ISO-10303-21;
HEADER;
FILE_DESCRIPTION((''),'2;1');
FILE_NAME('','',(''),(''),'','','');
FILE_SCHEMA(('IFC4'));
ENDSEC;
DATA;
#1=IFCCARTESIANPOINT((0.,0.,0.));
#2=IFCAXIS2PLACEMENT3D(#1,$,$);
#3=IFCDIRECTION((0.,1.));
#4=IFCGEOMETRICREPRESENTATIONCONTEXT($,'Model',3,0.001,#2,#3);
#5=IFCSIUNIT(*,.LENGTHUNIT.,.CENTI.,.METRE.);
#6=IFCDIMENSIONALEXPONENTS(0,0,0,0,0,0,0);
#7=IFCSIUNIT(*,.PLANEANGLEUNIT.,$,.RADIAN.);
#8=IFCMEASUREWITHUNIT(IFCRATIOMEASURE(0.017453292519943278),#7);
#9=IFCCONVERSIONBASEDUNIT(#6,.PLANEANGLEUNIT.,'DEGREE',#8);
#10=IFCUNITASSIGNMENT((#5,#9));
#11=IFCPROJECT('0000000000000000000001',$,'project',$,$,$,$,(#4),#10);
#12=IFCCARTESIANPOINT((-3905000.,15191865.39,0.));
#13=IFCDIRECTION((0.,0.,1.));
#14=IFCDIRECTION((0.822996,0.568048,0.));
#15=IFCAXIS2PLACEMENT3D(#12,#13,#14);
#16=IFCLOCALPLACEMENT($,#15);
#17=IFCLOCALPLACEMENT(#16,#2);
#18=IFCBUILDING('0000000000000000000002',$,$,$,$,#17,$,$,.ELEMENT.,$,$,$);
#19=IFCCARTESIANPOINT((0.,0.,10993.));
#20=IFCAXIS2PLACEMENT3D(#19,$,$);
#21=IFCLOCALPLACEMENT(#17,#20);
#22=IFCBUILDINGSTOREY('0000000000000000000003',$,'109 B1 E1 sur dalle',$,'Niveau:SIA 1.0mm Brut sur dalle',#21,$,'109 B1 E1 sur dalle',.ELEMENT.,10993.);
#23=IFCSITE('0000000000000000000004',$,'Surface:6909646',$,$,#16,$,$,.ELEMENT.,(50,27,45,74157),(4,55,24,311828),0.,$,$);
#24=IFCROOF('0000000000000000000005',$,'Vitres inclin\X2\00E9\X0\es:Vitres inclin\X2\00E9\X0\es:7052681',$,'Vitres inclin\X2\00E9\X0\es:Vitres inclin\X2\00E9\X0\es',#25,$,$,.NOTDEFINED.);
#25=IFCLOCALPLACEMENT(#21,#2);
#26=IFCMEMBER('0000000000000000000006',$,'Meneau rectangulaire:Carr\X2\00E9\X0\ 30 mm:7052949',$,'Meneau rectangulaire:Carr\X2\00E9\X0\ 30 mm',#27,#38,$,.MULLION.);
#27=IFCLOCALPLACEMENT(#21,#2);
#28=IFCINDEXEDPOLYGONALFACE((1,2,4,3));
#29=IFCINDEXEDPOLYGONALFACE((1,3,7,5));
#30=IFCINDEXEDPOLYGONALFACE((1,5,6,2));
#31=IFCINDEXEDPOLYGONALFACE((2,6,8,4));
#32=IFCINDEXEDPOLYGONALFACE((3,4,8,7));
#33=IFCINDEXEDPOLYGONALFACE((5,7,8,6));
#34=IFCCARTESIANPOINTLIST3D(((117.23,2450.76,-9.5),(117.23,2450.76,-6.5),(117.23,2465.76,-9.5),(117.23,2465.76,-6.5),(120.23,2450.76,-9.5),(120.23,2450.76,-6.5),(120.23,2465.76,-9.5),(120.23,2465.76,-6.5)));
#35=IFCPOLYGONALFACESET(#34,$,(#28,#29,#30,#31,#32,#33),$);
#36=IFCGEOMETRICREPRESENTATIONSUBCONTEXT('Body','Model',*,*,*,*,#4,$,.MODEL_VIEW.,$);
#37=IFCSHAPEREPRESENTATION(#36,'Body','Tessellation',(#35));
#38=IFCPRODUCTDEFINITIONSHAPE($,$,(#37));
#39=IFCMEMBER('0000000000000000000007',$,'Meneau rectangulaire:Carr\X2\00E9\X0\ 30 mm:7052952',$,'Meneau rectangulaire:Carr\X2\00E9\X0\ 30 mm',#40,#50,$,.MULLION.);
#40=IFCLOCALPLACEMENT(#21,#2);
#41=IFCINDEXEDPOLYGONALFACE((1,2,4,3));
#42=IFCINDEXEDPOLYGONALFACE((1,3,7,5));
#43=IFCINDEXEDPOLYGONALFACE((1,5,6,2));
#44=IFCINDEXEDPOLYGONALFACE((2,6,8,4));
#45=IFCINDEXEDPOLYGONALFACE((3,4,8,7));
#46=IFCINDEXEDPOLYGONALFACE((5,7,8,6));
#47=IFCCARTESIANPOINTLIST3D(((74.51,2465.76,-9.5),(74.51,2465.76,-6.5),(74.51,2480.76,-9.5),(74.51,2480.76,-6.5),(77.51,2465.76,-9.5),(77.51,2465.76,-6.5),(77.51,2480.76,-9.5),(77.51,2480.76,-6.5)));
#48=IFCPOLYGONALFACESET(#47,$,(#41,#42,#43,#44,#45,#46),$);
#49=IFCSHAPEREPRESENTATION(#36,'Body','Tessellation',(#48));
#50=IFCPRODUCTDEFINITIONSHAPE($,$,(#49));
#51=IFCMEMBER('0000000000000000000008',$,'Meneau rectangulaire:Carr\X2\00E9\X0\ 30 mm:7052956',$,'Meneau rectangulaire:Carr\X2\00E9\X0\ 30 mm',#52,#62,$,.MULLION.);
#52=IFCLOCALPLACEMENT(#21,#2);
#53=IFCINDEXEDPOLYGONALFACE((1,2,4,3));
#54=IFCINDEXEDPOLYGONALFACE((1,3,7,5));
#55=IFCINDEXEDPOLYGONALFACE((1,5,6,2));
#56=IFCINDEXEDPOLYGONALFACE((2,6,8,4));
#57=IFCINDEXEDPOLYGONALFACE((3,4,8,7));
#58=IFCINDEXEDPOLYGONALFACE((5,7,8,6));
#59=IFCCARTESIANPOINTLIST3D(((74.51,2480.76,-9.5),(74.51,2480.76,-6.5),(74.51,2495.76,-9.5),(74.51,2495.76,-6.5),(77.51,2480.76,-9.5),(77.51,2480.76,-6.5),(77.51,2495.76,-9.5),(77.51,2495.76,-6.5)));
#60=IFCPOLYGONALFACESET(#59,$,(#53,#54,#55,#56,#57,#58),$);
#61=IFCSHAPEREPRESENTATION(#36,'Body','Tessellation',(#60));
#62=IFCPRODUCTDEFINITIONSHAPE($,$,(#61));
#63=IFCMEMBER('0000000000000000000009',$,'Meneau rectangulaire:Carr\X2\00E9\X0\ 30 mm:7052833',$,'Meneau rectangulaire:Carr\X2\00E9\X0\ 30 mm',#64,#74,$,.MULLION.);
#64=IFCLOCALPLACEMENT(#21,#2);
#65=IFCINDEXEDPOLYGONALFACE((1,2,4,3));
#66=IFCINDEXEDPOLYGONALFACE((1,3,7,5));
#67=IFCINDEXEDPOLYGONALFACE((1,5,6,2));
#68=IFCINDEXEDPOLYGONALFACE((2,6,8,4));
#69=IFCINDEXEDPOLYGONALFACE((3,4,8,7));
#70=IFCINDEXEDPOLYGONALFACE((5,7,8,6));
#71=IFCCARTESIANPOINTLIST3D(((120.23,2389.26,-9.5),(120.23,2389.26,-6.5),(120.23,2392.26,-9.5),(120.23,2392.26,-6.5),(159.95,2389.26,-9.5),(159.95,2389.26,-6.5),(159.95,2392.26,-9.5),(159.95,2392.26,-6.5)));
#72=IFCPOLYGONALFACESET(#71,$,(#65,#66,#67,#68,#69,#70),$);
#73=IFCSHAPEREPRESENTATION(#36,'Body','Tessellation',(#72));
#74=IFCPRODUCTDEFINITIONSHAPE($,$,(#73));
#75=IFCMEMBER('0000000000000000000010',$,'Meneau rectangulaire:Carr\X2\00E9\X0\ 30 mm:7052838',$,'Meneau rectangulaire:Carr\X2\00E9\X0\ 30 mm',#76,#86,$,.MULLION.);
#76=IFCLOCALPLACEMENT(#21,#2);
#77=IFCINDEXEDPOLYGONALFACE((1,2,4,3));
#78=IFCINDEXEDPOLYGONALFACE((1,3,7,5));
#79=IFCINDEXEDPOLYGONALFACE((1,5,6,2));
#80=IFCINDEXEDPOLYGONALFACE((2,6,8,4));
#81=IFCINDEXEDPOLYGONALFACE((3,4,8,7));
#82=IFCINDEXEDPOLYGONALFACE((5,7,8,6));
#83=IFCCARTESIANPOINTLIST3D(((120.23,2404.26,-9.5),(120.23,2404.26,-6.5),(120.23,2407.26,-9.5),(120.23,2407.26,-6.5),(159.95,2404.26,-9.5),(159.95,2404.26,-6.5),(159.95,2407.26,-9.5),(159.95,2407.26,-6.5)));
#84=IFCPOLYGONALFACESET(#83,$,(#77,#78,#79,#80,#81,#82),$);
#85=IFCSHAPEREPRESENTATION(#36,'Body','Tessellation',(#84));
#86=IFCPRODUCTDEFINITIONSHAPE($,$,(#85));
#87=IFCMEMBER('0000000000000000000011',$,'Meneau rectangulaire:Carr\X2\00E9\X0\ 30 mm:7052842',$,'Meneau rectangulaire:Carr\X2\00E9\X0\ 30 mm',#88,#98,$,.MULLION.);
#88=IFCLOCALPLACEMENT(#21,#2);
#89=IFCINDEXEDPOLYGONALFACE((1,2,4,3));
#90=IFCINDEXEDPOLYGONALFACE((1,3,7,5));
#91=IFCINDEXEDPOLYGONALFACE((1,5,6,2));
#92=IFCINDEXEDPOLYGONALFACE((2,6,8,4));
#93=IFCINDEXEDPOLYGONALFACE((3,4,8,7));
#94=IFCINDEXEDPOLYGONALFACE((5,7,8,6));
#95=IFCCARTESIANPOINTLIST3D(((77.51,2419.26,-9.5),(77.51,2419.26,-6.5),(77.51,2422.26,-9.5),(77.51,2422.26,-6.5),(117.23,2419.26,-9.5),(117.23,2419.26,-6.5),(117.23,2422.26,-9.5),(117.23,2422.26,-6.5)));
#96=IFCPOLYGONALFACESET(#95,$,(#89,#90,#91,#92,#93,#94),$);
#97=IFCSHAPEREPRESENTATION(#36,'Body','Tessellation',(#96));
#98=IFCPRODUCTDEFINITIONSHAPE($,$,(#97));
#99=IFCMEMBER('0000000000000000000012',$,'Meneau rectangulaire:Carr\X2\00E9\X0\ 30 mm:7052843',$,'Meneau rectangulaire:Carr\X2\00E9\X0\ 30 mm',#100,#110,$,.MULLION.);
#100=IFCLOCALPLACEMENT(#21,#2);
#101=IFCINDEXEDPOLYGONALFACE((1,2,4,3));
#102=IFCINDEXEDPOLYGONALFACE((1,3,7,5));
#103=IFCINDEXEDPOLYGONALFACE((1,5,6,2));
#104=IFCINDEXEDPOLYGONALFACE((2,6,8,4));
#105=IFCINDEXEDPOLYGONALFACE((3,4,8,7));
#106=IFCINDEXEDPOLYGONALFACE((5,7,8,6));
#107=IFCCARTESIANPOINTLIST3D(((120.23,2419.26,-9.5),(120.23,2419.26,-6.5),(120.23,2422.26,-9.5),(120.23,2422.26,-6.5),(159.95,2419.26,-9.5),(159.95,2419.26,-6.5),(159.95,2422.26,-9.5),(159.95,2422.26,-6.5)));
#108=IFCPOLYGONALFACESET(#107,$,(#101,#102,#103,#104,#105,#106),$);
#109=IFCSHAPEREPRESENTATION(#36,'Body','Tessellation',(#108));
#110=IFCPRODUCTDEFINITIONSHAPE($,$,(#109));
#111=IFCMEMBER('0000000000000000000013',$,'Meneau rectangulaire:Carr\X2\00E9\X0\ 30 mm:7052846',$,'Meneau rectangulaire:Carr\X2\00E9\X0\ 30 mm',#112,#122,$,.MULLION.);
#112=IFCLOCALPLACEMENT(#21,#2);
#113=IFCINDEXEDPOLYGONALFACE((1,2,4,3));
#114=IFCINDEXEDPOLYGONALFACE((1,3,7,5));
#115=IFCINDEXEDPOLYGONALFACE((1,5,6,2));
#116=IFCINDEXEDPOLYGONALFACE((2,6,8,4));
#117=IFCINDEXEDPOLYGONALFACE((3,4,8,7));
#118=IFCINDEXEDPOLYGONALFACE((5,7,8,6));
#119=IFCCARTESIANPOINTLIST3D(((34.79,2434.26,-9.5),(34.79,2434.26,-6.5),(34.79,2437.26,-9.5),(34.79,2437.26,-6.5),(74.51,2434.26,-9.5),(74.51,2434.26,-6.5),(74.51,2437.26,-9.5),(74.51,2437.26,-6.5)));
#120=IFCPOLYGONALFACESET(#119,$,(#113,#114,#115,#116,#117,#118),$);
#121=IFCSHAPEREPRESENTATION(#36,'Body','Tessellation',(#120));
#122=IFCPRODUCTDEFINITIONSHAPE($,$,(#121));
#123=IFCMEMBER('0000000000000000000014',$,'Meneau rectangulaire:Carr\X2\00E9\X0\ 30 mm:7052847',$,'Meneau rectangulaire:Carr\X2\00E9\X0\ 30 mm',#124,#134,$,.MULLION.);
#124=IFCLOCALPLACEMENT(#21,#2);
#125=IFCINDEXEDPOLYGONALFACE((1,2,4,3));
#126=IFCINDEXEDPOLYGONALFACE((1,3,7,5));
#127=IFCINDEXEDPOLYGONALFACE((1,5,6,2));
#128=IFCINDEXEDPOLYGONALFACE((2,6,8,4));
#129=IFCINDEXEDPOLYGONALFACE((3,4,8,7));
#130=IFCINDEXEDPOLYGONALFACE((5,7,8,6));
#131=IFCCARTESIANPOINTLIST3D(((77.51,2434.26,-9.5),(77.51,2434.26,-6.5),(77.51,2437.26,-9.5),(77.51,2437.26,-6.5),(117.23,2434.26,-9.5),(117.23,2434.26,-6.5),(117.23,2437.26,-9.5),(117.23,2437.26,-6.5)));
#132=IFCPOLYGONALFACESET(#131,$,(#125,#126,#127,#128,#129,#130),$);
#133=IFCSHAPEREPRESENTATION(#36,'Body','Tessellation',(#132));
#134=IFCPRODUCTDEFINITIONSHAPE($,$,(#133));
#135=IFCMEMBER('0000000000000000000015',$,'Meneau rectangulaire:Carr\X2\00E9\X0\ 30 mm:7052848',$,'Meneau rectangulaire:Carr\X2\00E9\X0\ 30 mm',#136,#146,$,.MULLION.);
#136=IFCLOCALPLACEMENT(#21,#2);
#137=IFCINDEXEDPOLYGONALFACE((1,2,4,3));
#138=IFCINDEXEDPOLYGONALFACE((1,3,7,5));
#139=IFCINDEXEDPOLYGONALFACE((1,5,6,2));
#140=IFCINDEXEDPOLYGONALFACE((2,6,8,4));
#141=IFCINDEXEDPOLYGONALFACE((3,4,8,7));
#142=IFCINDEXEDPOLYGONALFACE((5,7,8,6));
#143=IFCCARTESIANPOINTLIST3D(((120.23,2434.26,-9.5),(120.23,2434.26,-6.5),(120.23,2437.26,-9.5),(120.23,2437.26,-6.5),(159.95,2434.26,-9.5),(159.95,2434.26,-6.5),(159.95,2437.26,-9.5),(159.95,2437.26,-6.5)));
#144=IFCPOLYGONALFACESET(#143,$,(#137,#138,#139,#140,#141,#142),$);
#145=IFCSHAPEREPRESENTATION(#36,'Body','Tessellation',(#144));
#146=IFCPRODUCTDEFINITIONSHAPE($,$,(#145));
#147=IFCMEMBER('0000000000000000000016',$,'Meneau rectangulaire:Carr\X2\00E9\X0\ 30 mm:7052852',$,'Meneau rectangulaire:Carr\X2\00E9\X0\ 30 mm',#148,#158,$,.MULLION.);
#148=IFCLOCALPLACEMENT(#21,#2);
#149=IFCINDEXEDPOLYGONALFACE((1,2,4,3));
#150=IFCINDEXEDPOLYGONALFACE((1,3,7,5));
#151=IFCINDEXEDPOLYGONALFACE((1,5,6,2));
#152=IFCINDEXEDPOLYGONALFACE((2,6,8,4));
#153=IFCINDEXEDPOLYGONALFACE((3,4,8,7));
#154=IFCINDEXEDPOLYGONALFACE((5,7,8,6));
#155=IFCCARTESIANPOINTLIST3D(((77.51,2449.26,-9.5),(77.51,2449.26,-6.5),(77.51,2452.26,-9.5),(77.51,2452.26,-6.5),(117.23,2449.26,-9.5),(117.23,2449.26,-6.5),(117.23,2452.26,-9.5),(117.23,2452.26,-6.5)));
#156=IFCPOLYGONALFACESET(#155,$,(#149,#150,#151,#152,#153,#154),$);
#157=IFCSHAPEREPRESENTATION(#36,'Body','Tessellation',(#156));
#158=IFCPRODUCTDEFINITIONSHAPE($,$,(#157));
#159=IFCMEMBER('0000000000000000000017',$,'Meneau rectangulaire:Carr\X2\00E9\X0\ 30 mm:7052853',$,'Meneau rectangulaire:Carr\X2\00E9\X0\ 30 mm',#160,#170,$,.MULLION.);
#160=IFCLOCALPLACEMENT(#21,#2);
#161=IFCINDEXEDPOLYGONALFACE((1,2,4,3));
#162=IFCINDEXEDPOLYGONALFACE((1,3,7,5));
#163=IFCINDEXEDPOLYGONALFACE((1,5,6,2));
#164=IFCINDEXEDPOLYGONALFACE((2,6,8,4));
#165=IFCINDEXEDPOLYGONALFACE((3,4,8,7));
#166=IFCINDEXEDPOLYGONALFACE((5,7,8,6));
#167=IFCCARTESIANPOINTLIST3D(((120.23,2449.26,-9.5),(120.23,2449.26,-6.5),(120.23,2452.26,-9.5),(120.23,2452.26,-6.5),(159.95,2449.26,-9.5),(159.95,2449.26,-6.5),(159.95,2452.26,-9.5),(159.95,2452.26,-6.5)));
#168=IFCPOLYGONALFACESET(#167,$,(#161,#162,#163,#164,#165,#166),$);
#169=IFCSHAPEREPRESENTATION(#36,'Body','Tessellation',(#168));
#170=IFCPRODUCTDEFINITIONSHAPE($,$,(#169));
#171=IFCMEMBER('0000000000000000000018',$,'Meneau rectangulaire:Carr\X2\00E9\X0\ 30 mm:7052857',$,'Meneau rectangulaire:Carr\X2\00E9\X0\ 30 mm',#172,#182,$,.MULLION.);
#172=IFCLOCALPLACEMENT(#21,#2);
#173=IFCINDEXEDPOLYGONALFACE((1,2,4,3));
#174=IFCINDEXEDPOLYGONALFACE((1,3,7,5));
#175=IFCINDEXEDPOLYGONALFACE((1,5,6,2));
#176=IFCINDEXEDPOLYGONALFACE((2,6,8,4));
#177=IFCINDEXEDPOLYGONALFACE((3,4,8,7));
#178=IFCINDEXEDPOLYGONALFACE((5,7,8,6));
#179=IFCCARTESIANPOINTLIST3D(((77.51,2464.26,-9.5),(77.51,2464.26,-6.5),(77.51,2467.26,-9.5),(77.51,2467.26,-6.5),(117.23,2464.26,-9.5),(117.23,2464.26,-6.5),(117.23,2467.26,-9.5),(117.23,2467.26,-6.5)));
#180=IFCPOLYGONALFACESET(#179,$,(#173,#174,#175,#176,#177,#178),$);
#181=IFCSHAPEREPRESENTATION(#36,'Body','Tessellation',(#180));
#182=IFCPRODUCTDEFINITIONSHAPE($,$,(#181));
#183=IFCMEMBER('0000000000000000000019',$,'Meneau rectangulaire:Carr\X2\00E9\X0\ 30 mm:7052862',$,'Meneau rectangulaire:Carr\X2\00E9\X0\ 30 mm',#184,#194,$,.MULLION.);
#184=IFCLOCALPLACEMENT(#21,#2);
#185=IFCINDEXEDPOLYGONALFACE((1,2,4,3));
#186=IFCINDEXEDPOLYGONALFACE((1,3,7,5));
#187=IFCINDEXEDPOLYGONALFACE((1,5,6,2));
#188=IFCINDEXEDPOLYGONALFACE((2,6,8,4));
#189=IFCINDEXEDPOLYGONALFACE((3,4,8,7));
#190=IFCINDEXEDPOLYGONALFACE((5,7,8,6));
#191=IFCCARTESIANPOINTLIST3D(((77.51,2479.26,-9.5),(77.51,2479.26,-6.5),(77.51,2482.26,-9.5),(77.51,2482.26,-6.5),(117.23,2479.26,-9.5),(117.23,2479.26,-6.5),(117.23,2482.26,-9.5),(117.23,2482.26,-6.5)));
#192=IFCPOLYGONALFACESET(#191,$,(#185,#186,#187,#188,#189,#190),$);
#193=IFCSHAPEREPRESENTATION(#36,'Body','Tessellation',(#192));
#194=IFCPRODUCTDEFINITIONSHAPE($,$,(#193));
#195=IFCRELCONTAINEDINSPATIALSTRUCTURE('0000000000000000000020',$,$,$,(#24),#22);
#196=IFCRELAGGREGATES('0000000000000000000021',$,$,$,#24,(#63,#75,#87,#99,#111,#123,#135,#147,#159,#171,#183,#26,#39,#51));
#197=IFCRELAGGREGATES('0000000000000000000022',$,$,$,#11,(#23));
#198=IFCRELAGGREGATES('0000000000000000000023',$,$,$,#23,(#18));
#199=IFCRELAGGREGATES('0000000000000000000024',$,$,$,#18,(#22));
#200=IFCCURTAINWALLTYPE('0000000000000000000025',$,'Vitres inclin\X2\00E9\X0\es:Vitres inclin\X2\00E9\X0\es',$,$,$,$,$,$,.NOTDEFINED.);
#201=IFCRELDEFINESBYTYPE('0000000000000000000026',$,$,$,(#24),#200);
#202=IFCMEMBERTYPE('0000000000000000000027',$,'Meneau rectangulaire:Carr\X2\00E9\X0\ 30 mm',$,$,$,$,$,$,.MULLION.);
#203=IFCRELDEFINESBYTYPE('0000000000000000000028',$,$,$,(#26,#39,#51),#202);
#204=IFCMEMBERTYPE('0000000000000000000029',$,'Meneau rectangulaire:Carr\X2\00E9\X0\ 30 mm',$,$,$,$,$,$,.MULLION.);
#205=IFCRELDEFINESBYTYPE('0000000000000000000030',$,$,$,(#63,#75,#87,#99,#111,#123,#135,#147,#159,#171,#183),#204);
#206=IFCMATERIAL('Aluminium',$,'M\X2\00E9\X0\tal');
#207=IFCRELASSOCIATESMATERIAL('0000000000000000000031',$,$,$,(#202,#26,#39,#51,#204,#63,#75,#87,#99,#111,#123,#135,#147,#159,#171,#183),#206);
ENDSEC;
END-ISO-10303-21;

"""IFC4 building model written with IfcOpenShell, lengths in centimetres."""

from ifc_helpers import new_model, entity, si_unit, converted_unit, direction, frame, origin, place, context, subcontext, project, spatial, indexed_curve, outline, extrude, source, transform, mapped, material, type_object, type_shapes, element, aggregate, save


model = new_model("IFC4")

# Units and contexts
model_context = context("Model", 3, precision=0.001, world=origin(), true_north=direction((0.0, 1.0)))
body_context = subcontext(model_context, "Body", "Model", "MODEL_VIEW")
ifc_project = project(units=[si_unit("LENGTHUNIT", "METRE", prefix="CENTI"), converted_unit("PLANEANGLEUNIT", "DEGREE", entity("IfcRatioMeasure", 0.017453292519943278), si_unit("PLANEANGLEUNIT", "RADIAN"), dimensions=[0, 0, 0, 0, 0, 0, 0])], contexts=[model_context])

# Site, building, storey
site_placement = place(None, frame((-3905000.0, 15191865.39, 0.0), z_axis=(0.0, 0.0, 1.0), x_axis=(0.822996, 0.568048, 0.0)))
site = spatial("IfcSite", under=ifc_project, at=site_placement, Name="Surface:6909646", CompositionType="ELEMENT", RefLatitude=(50, 27, 45, 74157), RefLongitude=(4, 55, 24, 311828), RefElevation=0.0)
building_placement = place(site_placement, origin())
building = spatial("IfcBuilding", under=site, at=building_placement, CompositionType="ELEMENT")
storey_placement = place(building_placement, frame((0.0, 0.0, 10993.0)))
storey = spatial("IfcBuildingStorey", under=building, at=storey_placement, Name="109 B1 E1 sur dalle", ObjectType="Niveau:SIA 1.0mm Brut sur dalle", LongName="109 B1 E1 sur dalle", CompositionType="ELEMENT", Elevation=10993.0)

# Roof, members
curtain_wall_type = type_object("IfcCurtainWallType", Name="Vitres inclinées:Vitres inclinées", PredefinedType="NOTDEFINED")
roof_placement = place(storey_placement, frame((0.0, 0.0, -10993.0)))
roof = element("IfcRoof", 1, at=roof_placement, inside=storey, type_object=curtain_wall_type, Name="Vitres inclinées:Vitres inclinées:7052681", ObjectType="Vitres inclinées:Vitres inclinées", PredefinedType="NOTDEFINED")
ifc_material = material(Name="Aluminium", Category="Métal")
member_type_1 = type_object("IfcMemberType", Name="Meneau rectangulaire:Carré 30 mm", PredefinedType="MULLION", material=ifc_material)
shared_shape_1 = source(origin(), body_context, "Body", "SweptSolid", [
    extrude(outline(indexed_curve([(-1.5, -1.5), (1.5, -1.5), (1.5, 1.5), (-1.5, 1.5), (-1.5, -1.5)], self_intersect=False)), frame((0.0, 0.0, -15.0), z_axis=(0.0, 0.0, 1.0), x_axis=(0.0, -1.0, 0.0)), (0.0, 0.0, 1.0), 15.0),
])
type_shapes(member_type_1, [shared_shape_1])
member_1_placement = place(roof_placement, frame((118.73, 2465.76, 10985.0), z_axis=(0.0, 1.0, 0.0), x_axis=(1.0, 0.0, 0.0)))
member_1 = element("IfcMember", 2, at=member_1_placement, type_object=member_type_1, material=ifc_material, Name="Meneau rectangulaire:Carré 30 mm:7052949", ObjectType="Meneau rectangulaire:Carré 30 mm", PredefinedType="MULLION", context=body_context, shape_type="MappedRepresentation", body=[
    mapped(shared_shape_1, transform((0.0, 0.0, 0.0), scale=1.0)),
])
member_2_placement = place(roof_placement, frame((76.01, 2480.76, 10985.0), z_axis=(0.0, 1.0, 0.0), x_axis=(1.0, 0.0, 0.0)))
member_2 = element("IfcMember", 3, at=member_2_placement, type_object=member_type_1, material=ifc_material, Name="Meneau rectangulaire:Carré 30 mm:7052952", ObjectType="Meneau rectangulaire:Carré 30 mm", PredefinedType="MULLION", context=body_context, shape_type="MappedRepresentation", body=[
    mapped(shared_shape_1, transform((0.0, 0.0, 0.0), scale=1.0)),
])
member_3_placement = place(roof_placement, frame((76.01, 2495.76, 10985.0), z_axis=(0.0, 1.0, 0.0), x_axis=(1.0, 0.0, 0.0)))
member_3 = element("IfcMember", 4, at=member_3_placement, type_object=member_type_1, material=ifc_material, Name="Meneau rectangulaire:Carré 30 mm:7052956", ObjectType="Meneau rectangulaire:Carré 30 mm", PredefinedType="MULLION", context=body_context, shape_type="MappedRepresentation", body=[
    mapped(shared_shape_1, transform((0.0, 0.0, 0.0), scale=1.0)),
])
member_type_2 = type_object("IfcMemberType", Name="Meneau rectangulaire:Carré 30 mm", PredefinedType="MULLION", material=ifc_material)
shared_shape_2 = source(origin(), body_context, "Body", "SweptSolid", [
    extrude(outline(indexed_curve([(-1.5, -1.5), (1.5, -1.5), (1.5, 1.5), (-1.5, 1.5), (-1.5, -1.5)], self_intersect=False)), frame((0.0, 0.0, -39.72), z_axis=(0.0, 0.0, 1.0), x_axis=(0.0, -1.0, 0.0)), (0.0, 0.0, 1.0), 39.72),
])
type_shapes(member_type_2, [shared_shape_2])
member_4_placement = place(roof_placement, frame((120.23, 2390.76, 10985.0), z_axis=(-1.0, 0.0, 0.0), x_axis=(0.0, 1.0, 0.0)))
member_4 = element("IfcMember", 5, at=member_4_placement, type_object=member_type_2, material=ifc_material, Name="Meneau rectangulaire:Carré 30 mm:7052833", ObjectType="Meneau rectangulaire:Carré 30 mm", PredefinedType="MULLION", context=body_context, shape_type="MappedRepresentation", body=[
    mapped(shared_shape_2, transform((0.0, 0.0, 0.0), scale=1.0)),
])
member_5_placement = place(roof_placement, frame((120.23, 2405.76, 10985.0), z_axis=(-1.0, 0.0, 0.0), x_axis=(0.0, 1.0, 0.0)))
member_5 = element("IfcMember", 6, at=member_5_placement, type_object=member_type_2, material=ifc_material, Name="Meneau rectangulaire:Carré 30 mm:7052838", ObjectType="Meneau rectangulaire:Carré 30 mm", PredefinedType="MULLION", context=body_context, shape_type="MappedRepresentation", body=[
    mapped(shared_shape_2, transform((0.0, 0.0, 0.0), scale=1.0)),
])
member_6_placement = place(roof_placement, frame((77.51, 2420.76, 10985.0), z_axis=(-1.0, 0.0, 0.0), x_axis=(0.0, 1.0, 0.0)))
member_6 = element("IfcMember", 7, at=member_6_placement, type_object=member_type_2, material=ifc_material, Name="Meneau rectangulaire:Carré 30 mm:7052842", ObjectType="Meneau rectangulaire:Carré 30 mm", PredefinedType="MULLION", context=body_context, shape_type="MappedRepresentation", body=[
    mapped(shared_shape_2, transform((0.0, 0.0, 0.0), scale=1.0)),
])
member_7_placement = place(roof_placement, frame((120.23, 2420.76, 10985.0), z_axis=(-1.0, 0.0, 0.0), x_axis=(0.0, 1.0, 0.0)))
member_7 = element("IfcMember", 8, at=member_7_placement, type_object=member_type_2, material=ifc_material, Name="Meneau rectangulaire:Carré 30 mm:7052843", ObjectType="Meneau rectangulaire:Carré 30 mm", PredefinedType="MULLION", context=body_context, shape_type="MappedRepresentation", body=[
    mapped(shared_shape_2, transform((0.0, 0.0, 0.0), scale=1.0)),
])
member_8_placement = place(roof_placement, frame((34.79, 2435.76, 10985.0), z_axis=(-1.0, 0.0, 0.0), x_axis=(0.0, 1.0, 0.0)))
member_8 = element("IfcMember", 9, at=member_8_placement, type_object=member_type_2, material=ifc_material, Name="Meneau rectangulaire:Carré 30 mm:7052846", ObjectType="Meneau rectangulaire:Carré 30 mm", PredefinedType="MULLION", context=body_context, shape_type="MappedRepresentation", body=[
    mapped(shared_shape_2, transform((0.0, 0.0, 0.0), scale=1.0)),
])
member_9_placement = place(roof_placement, frame((77.51, 2435.76, 10985.0), z_axis=(-1.0, 0.0, 0.0), x_axis=(0.0, 1.0, 0.0)))
member_9 = element("IfcMember", 10, at=member_9_placement, type_object=member_type_2, material=ifc_material, Name="Meneau rectangulaire:Carré 30 mm:7052847", ObjectType="Meneau rectangulaire:Carré 30 mm", PredefinedType="MULLION", context=body_context, shape_type="MappedRepresentation", body=[
    mapped(shared_shape_2, transform((0.0, 0.0, 0.0), scale=1.0)),
])
member_10_placement = place(roof_placement, frame((120.23, 2435.76, 10985.0), z_axis=(-1.0, 0.0, 0.0), x_axis=(0.0, 1.0, 0.0)))
member_10 = element("IfcMember", 11, at=member_10_placement, type_object=member_type_2, material=ifc_material, Name="Meneau rectangulaire:Carré 30 mm:7052848", ObjectType="Meneau rectangulaire:Carré 30 mm", PredefinedType="MULLION", context=body_context, shape_type="MappedRepresentation", body=[
    mapped(shared_shape_2, transform((0.0, 0.0, 0.0), scale=1.0)),
])
member_11_placement = place(roof_placement, frame((77.51, 2450.76, 10985.0), z_axis=(-1.0, 0.0, 0.0), x_axis=(0.0, 1.0, 0.0)))
member_11 = element("IfcMember", 12, at=member_11_placement, type_object=member_type_2, material=ifc_material, Name="Meneau rectangulaire:Carré 30 mm:7052852", ObjectType="Meneau rectangulaire:Carré 30 mm", PredefinedType="MULLION", context=body_context, shape_type="MappedRepresentation", body=[
    mapped(shared_shape_2, transform((0.0, 0.0, 0.0), scale=1.0)),
])
member_12_placement = place(roof_placement, frame((120.23, 2450.76, 10985.0), z_axis=(-1.0, 0.0, 0.0), x_axis=(0.0, 1.0, 0.0)))
member_12 = element("IfcMember", 13, at=member_12_placement, type_object=member_type_2, material=ifc_material, Name="Meneau rectangulaire:Carré 30 mm:7052853", ObjectType="Meneau rectangulaire:Carré 30 mm", PredefinedType="MULLION", context=body_context, shape_type="MappedRepresentation", body=[
    mapped(shared_shape_2, transform((0.0, 0.0, 0.0), scale=1.0)),
])
member_13_placement = place(roof_placement, frame((77.51, 2465.76, 10985.0), z_axis=(-1.0, 0.0, 0.0), x_axis=(0.0, 1.0, 0.0)))
member_13 = element("IfcMember", 14, at=member_13_placement, type_object=member_type_2, material=ifc_material, Name="Meneau rectangulaire:Carré 30 mm:7052857", ObjectType="Meneau rectangulaire:Carré 30 mm", PredefinedType="MULLION", context=body_context, shape_type="MappedRepresentation", body=[
    mapped(shared_shape_2, transform((0.0, 0.0, 0.0), scale=1.0)),
])
member_14_placement = place(roof_placement, frame((77.51, 2480.76, 10985.0), z_axis=(-1.0, 0.0, 0.0), x_axis=(0.0, 1.0, 0.0)))
member_14 = element("IfcMember", 15, at=member_14_placement, type_object=member_type_2, material=ifc_material, Name="Meneau rectangulaire:Carré 30 mm:7052862", ObjectType="Meneau rectangulaire:Carré 30 mm", PredefinedType="MULLION", context=body_context, shape_type="MappedRepresentation", body=[
    mapped(shared_shape_2, transform((0.0, 0.0, 0.0), scale=1.0)),
])
aggregate(roof, [member_4, member_5, member_6, member_7, member_8, member_9, member_10, member_11, member_12, member_13, member_14, member_1, member_2, member_3])

save(model, "model.ifc")
